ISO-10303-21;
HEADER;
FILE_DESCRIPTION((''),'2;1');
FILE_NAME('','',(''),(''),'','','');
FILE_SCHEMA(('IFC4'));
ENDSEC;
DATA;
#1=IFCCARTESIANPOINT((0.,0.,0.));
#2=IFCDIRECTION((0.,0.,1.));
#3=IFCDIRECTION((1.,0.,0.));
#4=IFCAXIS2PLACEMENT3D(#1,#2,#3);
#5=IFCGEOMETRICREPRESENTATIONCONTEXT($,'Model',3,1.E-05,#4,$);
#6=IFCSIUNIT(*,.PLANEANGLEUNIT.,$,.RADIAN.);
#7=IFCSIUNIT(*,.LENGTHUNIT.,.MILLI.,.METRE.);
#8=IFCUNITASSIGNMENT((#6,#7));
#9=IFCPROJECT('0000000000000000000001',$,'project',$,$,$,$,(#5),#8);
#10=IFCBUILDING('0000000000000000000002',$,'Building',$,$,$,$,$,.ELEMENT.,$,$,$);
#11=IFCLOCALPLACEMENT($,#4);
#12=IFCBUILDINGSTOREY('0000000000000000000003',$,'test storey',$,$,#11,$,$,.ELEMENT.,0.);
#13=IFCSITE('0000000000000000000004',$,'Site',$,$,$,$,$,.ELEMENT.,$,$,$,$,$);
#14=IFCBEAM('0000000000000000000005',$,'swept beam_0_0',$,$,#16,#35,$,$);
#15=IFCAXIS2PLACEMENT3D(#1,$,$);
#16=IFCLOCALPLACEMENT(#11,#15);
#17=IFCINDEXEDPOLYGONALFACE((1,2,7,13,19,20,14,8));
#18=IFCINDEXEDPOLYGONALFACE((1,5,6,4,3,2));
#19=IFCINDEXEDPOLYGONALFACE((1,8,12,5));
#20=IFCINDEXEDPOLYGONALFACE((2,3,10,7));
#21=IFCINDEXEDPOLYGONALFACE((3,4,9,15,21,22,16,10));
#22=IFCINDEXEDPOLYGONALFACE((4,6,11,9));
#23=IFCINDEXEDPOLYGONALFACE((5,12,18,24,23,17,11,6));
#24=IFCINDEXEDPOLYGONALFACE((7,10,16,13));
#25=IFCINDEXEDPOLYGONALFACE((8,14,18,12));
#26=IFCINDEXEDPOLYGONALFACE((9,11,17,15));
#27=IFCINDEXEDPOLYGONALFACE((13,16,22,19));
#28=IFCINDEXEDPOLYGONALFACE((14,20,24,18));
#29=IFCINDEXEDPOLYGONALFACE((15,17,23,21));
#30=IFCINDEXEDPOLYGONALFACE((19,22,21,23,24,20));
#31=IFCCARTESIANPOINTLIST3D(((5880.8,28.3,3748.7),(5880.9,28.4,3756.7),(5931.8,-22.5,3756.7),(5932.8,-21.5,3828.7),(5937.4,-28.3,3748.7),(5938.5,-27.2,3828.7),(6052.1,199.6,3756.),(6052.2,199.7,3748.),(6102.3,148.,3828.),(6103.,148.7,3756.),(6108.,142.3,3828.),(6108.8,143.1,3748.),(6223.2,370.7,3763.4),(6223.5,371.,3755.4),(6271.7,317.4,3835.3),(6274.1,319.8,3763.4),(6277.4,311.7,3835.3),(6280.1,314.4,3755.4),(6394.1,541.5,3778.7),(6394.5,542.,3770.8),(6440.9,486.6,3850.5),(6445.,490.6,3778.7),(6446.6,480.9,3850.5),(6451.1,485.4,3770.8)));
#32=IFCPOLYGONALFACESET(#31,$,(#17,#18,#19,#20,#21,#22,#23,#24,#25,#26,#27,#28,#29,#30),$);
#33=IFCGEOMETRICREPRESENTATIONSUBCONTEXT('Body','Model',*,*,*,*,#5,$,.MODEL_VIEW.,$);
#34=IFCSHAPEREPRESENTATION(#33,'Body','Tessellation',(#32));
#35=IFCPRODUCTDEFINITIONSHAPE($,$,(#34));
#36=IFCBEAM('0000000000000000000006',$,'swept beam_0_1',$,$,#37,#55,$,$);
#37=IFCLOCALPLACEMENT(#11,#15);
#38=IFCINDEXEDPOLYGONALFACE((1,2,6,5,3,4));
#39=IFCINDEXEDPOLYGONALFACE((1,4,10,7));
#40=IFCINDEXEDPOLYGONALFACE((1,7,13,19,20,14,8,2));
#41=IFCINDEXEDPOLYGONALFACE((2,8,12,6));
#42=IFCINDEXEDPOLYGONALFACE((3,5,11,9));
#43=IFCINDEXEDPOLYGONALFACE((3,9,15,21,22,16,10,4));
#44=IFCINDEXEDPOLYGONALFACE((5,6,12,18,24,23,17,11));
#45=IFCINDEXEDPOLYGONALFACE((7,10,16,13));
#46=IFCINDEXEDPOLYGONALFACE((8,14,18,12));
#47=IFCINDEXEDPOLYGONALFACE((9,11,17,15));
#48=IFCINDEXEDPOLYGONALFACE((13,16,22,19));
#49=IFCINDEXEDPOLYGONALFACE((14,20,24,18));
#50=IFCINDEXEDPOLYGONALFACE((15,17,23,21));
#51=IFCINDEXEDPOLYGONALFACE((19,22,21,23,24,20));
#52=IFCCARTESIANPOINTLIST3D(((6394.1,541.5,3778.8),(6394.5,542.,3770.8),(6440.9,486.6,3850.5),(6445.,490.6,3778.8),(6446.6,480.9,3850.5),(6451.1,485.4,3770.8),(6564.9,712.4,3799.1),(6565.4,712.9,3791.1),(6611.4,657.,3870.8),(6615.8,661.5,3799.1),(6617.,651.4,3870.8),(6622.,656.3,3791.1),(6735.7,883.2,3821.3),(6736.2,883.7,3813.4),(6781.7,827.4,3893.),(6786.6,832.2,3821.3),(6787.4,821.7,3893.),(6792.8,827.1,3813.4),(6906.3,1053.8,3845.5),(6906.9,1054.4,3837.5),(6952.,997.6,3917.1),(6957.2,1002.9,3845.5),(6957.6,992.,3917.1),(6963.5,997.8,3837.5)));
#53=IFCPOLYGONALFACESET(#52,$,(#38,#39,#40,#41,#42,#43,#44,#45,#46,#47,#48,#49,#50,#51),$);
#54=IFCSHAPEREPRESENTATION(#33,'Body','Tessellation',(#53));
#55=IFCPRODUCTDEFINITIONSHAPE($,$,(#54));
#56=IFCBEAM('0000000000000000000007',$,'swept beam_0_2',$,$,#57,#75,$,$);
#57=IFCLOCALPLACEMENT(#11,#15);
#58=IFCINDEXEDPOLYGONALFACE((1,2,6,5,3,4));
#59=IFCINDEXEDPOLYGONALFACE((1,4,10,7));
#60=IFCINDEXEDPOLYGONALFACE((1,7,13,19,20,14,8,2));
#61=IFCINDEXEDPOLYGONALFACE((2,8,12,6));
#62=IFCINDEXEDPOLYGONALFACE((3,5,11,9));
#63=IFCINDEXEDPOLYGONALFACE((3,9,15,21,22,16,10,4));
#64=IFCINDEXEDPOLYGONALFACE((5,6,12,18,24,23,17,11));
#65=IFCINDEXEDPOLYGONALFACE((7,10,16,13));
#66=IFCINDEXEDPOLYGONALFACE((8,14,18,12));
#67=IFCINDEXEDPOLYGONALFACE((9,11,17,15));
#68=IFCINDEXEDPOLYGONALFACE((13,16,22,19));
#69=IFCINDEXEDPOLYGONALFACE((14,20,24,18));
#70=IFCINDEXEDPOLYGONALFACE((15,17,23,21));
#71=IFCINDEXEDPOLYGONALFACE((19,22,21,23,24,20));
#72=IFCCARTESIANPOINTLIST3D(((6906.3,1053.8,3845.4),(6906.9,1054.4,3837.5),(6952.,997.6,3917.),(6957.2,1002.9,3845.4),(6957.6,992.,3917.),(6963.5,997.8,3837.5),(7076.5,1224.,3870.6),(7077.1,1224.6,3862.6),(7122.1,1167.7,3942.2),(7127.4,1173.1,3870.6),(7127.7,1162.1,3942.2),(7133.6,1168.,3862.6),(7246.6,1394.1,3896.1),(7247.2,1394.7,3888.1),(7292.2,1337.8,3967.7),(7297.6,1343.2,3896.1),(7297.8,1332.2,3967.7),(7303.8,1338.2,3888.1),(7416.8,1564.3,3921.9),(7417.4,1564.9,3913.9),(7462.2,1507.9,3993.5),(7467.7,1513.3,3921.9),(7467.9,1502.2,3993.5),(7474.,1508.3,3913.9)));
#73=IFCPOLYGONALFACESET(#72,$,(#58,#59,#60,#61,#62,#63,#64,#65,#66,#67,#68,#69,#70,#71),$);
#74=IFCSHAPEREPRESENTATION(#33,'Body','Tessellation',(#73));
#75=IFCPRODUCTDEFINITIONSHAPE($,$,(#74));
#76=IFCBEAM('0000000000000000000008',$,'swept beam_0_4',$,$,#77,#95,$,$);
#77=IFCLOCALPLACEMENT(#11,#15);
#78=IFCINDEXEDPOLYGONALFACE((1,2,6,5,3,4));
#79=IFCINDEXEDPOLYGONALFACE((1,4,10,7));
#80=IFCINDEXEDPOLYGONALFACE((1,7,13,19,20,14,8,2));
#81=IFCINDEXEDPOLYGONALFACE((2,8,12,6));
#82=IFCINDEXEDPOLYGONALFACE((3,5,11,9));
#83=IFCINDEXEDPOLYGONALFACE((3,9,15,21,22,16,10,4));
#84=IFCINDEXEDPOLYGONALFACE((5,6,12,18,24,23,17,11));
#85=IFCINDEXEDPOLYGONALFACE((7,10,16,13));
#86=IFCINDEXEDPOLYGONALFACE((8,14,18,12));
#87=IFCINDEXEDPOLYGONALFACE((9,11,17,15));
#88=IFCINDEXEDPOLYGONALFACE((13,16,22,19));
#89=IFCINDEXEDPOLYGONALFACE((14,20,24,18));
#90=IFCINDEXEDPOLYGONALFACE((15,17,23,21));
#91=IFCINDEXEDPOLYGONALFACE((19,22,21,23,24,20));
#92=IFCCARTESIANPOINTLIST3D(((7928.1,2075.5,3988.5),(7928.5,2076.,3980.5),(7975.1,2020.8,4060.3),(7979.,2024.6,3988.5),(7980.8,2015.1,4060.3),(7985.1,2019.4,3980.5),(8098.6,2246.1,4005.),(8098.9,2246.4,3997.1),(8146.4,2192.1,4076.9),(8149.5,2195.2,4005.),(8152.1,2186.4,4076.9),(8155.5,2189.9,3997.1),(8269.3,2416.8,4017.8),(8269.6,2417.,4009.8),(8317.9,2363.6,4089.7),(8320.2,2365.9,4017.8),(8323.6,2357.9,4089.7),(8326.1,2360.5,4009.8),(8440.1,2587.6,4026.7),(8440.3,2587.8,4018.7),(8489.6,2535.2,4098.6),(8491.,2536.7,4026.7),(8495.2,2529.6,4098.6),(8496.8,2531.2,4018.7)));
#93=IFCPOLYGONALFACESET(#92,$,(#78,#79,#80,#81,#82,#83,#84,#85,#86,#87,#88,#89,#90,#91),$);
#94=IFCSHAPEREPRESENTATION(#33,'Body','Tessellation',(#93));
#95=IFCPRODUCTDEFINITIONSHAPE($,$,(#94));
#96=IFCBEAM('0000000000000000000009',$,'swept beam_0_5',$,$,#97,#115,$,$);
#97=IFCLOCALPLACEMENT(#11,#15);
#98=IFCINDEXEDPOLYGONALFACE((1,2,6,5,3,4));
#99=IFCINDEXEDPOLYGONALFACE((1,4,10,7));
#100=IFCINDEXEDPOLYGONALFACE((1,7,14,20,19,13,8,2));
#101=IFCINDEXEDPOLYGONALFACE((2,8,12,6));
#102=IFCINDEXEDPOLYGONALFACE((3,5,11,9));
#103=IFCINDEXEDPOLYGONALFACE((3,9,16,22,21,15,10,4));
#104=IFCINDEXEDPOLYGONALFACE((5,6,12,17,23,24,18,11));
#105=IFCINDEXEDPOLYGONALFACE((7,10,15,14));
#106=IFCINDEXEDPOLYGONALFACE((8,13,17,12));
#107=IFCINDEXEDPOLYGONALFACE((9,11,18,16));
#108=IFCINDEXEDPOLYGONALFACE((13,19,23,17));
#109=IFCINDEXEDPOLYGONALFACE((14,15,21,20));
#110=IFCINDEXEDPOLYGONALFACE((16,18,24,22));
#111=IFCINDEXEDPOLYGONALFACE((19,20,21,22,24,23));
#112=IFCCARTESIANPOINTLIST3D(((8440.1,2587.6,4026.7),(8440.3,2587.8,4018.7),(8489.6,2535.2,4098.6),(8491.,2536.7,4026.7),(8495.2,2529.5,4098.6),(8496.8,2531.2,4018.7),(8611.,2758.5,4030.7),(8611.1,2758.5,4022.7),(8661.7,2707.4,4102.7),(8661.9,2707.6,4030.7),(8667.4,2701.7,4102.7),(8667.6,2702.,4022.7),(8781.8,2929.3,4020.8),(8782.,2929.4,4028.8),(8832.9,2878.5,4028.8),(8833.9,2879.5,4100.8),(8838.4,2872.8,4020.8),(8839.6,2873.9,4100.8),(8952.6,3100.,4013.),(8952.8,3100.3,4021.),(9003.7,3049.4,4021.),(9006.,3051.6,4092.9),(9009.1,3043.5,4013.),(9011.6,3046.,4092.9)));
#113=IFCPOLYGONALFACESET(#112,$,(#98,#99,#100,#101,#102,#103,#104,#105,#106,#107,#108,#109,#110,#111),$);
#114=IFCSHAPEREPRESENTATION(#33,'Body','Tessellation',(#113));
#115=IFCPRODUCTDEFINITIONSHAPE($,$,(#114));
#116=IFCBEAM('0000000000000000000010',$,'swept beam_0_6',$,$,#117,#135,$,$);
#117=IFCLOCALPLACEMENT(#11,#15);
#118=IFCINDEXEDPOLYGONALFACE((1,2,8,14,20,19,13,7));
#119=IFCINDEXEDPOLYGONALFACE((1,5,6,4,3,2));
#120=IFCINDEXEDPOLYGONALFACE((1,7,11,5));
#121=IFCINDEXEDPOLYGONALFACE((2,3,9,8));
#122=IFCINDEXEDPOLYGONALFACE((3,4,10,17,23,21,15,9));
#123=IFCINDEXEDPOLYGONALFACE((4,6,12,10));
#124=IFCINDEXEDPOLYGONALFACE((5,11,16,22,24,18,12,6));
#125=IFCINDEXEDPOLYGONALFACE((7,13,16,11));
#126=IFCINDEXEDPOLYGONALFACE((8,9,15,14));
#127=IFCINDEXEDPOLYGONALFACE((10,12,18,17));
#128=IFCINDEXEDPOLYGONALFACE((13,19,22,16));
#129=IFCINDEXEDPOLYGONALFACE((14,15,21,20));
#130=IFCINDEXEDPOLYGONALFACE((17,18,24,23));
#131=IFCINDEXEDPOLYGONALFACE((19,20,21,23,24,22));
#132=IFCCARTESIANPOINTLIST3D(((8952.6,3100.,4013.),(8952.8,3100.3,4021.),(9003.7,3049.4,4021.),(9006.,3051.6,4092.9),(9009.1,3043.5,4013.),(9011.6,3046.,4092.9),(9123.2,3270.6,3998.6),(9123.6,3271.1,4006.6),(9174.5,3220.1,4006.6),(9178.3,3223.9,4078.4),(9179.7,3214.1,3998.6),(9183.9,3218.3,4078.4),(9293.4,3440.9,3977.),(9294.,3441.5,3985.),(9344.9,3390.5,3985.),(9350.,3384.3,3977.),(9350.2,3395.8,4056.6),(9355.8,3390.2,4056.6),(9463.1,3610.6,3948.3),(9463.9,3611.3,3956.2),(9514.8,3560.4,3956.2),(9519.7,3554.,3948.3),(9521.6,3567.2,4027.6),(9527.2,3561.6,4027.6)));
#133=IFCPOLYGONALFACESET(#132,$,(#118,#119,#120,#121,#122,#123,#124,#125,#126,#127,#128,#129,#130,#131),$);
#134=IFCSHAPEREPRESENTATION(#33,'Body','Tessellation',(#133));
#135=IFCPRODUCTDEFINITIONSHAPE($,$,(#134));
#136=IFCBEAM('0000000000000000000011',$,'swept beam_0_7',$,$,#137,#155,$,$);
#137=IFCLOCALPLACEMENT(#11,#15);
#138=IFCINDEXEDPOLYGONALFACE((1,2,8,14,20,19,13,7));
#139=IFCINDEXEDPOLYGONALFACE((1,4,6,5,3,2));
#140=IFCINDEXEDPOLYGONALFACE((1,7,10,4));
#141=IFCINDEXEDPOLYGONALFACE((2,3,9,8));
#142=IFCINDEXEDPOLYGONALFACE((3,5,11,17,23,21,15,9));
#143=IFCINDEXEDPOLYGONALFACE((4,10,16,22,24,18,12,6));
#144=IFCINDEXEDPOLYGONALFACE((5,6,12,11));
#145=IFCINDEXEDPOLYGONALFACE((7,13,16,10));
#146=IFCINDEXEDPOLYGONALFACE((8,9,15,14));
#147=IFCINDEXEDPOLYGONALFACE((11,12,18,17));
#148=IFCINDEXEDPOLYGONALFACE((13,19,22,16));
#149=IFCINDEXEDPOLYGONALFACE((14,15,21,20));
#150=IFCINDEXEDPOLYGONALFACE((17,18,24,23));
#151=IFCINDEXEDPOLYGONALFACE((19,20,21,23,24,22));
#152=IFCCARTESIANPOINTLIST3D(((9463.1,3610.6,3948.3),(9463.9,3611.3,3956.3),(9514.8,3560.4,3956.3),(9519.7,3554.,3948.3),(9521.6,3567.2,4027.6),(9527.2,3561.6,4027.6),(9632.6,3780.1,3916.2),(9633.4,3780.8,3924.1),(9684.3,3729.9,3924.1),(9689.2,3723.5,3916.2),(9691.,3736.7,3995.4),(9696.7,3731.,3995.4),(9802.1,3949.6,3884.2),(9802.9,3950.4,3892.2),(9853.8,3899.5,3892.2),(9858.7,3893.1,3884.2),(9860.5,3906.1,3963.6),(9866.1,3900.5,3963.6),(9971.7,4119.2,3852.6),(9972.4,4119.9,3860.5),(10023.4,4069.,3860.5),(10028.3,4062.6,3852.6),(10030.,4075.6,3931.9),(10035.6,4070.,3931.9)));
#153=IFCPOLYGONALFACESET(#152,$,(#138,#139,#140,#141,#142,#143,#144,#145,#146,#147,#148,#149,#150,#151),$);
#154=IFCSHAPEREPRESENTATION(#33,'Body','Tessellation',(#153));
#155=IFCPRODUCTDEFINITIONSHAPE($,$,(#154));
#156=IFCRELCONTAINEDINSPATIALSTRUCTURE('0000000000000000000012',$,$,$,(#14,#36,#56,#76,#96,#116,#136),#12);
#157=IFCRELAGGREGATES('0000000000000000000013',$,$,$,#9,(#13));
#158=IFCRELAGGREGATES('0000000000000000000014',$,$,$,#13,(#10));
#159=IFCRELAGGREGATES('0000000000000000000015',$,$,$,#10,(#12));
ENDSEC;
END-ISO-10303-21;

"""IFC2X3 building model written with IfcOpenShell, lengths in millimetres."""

from ifc_helpers import new_model, entity, si_unit, origin_with_axes, place, context, subcontext, project, spatial, element, save


model = new_model("IFC2X3")

# Units and contexts
model_context = context("Model", 3, precision=1e-05, world=origin_with_axes())
body_context = subcontext(model_context, "Body", "Model", "MODEL_VIEW")
ifc_project = project(units=[si_unit("PLANEANGLEUNIT", "RADIAN"), si_unit("LENGTHUNIT", "METRE", prefix="MILLI")], contexts=[model_context])

# Site, building, storey
site = spatial("IfcSite", under=ifc_project, Name="Site", CompositionType="ELEMENT")
building = spatial("IfcBuilding", under=site, Name="Building", CompositionType="ELEMENT")
storey_placement = place(None, origin_with_axes())
storey = spatial("IfcBuildingStorey", under=building, at=storey_placement, Name="test storey", CompositionType="ELEMENT", Elevation=0.0)

# Beams
beam_1_placement = place(storey_placement, origin_with_axes())
element("IfcBeam", 1, at=beam_1_placement, inside=storey, Name="swept beam_0_0", context=body_context, shape_type="SweptSolid", body=[
    entity("IfcRevolvedAreaSolid", entity("IfcArbitraryClosedProfileDef", "AREA", None, entity("IfcPolyline", [entity("IfcCartesianPoint", [-80.0, 40.0]), entity("IfcCartesianPoint", [-80.0, 32.0]), entity("IfcCartesianPoint", [-8.0, 32.0]), entity("IfcCartesianPoint", [-8.0, -40.0]), entity("IfcCartesianPoint", [0.0, -40.0]), entity("IfcCartesianPoint", [0.0, 40.0]), entity("IfcCartesianPoint", [-80.0, 40.0])])), entity("IfcAxis2Placement3D", entity("IfcCartesianPoint", [5909.1, 0.0, 3748.7]), entity("IfcDirection", [-0.707, -0.707, 0.0193]), entity("IfcDirection", [-0.0136, -0.0136, -0.9998])), entity("IfcAxis1Placement", entity("IfcCartesianPoint", [-7320.5, 0.0, 0.0]), entity("IfcDirection", [0.0, 1.0, 0.0])), 0.099327),
])
beam_2_placement = place(storey_placement, origin_with_axes())
element("IfcBeam", 2, at=beam_2_placement, inside=storey, Name="swept beam_0_1", context=body_context, shape_type="SweptSolid", body=[
    entity("IfcRevolvedAreaSolid", entity("IfcArbitraryClosedProfileDef", "AREA", None, entity("IfcPolyline", [entity("IfcCartesianPoint", [-80.0, 40.0]), entity("IfcCartesianPoint", [-80.0, 32.0]), entity("IfcCartesianPoint", [-8.0, 32.0]), entity("IfcCartesianPoint", [-8.0, -40.0]), entity("IfcCartesianPoint", [0.0, -40.0]), entity("IfcCartesianPoint", [0.0, 40.0]), entity("IfcCartesianPoint", [-80.0, 40.0])])), entity("IfcAxis2Placement3D", entity("IfcCartesianPoint", [6422.8, 513.7, 3770.8]), entity("IfcDirection", [-0.7048, -0.7048, -0.08]), entity("IfcDirection", [0.0565, 0.0565, -0.9968])), entity("IfcAxis1Placement", entity("IfcCartesianPoint", [-31055.0, 0.0, 0.0]), entity("IfcDirection", [0.0, 1.0, 0.0])), 0.023432),
])
beam_3_placement = place(storey_placement, origin_with_axes())
element("IfcBeam", 3, at=beam_3_placement, inside=storey, Name="swept beam_0_2", context=body_context, shape_type="SweptSolid", body=[
    entity("IfcRevolvedAreaSolid", entity("IfcArbitraryClosedProfileDef", "AREA", None, entity("IfcPolyline", [entity("IfcCartesianPoint", [-80.0, 40.0]), entity("IfcCartesianPoint", [-80.0, 32.0]), entity("IfcCartesianPoint", [-8.0, 32.0]), entity("IfcCartesianPoint", [-8.0, -40.0]), entity("IfcCartesianPoint", [0.0, -40.0]), entity("IfcCartesianPoint", [0.0, 40.0]), entity("IfcCartesianPoint", [-80.0, 40.0])])), entity("IfcAxis2Placement3D", entity("IfcCartesianPoint", [6935.2, 1026.1, 3837.5]), entity("IfcDirection", [-0.7033, -0.7033, -0.1033]), entity("IfcDirection", [0.073, 0.073, -0.9946])), entity("IfcAxis1Placement", entity("IfcCartesianPoint", [-180625.6, 0.0, 0.0]), entity("IfcDirection", [0.0, 1.0, 0.0])), 0.004019),
])
beam_4_placement = place(storey_placement, origin_with_axes())
element("IfcBeam", 4, at=beam_4_placement, inside=storey, Name="swept beam_0_4", context=body_context, shape_type="SweptSolid", body=[
    entity("IfcRevolvedAreaSolid", entity("IfcArbitraryClosedProfileDef", "AREA", None, entity("IfcPolyline", [entity("IfcCartesianPoint", [80.0, -40.0]), entity("IfcCartesianPoint", [80.0, -32.0]), entity("IfcCartesianPoint", [8.0, -32.0]), entity("IfcCartesianPoint", [8.0, 40.0]), entity("IfcCartesianPoint", [0.0, 40.0]), entity("IfcCartesianPoint", [0.0, -40.0]), entity("IfcCartesianPoint", [80.0, -40.0])])), entity("IfcAxis2Placement3D", entity("IfcCartesianPoint", [7956.8, 2047.7, 3980.5]), entity("IfcDirection", [-0.705, -0.705, -0.0762]), entity("IfcDirection", [-0.0539, -0.0539, 0.9971])), entity("IfcAxis1Placement", entity("IfcCartesianPoint", [-15321.2, 0.0, 0.0]), entity("IfcDirection", [0.0, 1.0, 0.0])), 0.04731),
])
beam_5_placement = place(storey_placement, origin_with_axes())
element("IfcBeam", 5, at=beam_5_placement, inside=storey, Name="swept beam_0_5", context=body_context, shape_type="SweptSolid", body=[
    entity("IfcRevolvedAreaSolid", entity("IfcArbitraryClosedProfileDef", "AREA", None, entity("IfcPolyline", [entity("IfcCartesianPoint", [80.0, -40.0]), entity("IfcCartesianPoint", [80.0, -32.0]), entity("IfcCartesianPoint", [8.0, -32.0]), entity("IfcCartesianPoint", [8.0, 40.0]), entity("IfcCartesianPoint", [0.0, 40.0]), entity("IfcCartesianPoint", [0.0, -40.0]), entity("IfcCartesianPoint", [80.0, -40.0])])), entity("IfcAxis2Placement3D", entity("IfcCartesianPoint", [8468.6, 2559.5, 4018.7]), entity("IfcDirection", [-0.7068, -0.7068, -0.029]), entity("IfcDirection", [-0.0205, -0.0205, 0.9996])), entity("IfcAxis1Placement", entity("IfcCartesianPoint", [-9835.5, 0.0, 0.0]), entity("IfcDirection", [0.0, 1.0, 0.0])), 0.073677),
])
beam_6_placement = place(storey_placement, origin_with_axes())
element("IfcBeam", 6, at=beam_6_placement, inside=storey, Name="swept beam_0_6", context=body_context, shape_type="SweptSolid", body=[
    entity("IfcRevolvedAreaSolid", entity("IfcArbitraryClosedProfileDef", "AREA", None, entity("IfcPolyline", [entity("IfcCartesianPoint", [80.0, -40.0]), entity("IfcCartesianPoint", [80.0, -32.0]), entity("IfcCartesianPoint", [8.0, -32.0]), entity("IfcCartesianPoint", [8.0, 40.0]), entity("IfcCartesianPoint", [0.0, 40.0]), entity("IfcCartesianPoint", [0.0, -40.0]), entity("IfcCartesianPoint", [80.0, -40.0])])), entity("IfcAxis2Placement3D", entity("IfcCartesianPoint", [8980.8, 3071.7, 4013.0]), entity("IfcDirection", [-0.7064, -0.7064, 0.0447]), entity("IfcDirection", [0.0316, 0.0316, 0.999])), entity("IfcAxis1Placement", entity("IfcCartesianPoint", [-8123.6, 0.0, 0.0]), entity("IfcDirection", [0.0, 1.0, 0.0])), 0.089265),
])
beam_7_placement = place(storey_placement, origin_with_axes())
element("IfcBeam", 7, at=beam_7_placement, inside=storey, Name="swept beam_0_7", context=body_context, shape_type="SweptSolid", body=[
    entity("IfcRevolvedAreaSolid", entity("IfcArbitraryClosedProfileDef", "AREA", None, entity("IfcPolyline", [entity("IfcCartesianPoint", [-80.0, 40.0]), entity("IfcCartesianPoint", [-80.0, 32.0]), entity("IfcCartesianPoint", [-8.0, 32.0]), entity("IfcCartesianPoint", [-8.0, -40.0]), entity("IfcCartesianPoint", [0.0, -40.0]), entity("IfcCartesianPoint", [0.0, 40.0]), entity("IfcCartesianPoint", [-80.0, 40.0])])), entity("IfcAxis2Placement3D", entity("IfcCartesianPoint", [9491.4, 3582.3, 3948.3]), entity("IfcDirection", [-0.7008, -0.7008, 0.1336]), entity("IfcDirection", [-0.0944, -0.0944, -0.991])), entity("IfcAxis1Placement", entity("IfcCartesianPoint", [-213017.0, 0.0, 0.0]), entity("IfcDirection", [0.0, 1.0, 0.0])), 0.003406),
])

save(model, "model.ifc")
